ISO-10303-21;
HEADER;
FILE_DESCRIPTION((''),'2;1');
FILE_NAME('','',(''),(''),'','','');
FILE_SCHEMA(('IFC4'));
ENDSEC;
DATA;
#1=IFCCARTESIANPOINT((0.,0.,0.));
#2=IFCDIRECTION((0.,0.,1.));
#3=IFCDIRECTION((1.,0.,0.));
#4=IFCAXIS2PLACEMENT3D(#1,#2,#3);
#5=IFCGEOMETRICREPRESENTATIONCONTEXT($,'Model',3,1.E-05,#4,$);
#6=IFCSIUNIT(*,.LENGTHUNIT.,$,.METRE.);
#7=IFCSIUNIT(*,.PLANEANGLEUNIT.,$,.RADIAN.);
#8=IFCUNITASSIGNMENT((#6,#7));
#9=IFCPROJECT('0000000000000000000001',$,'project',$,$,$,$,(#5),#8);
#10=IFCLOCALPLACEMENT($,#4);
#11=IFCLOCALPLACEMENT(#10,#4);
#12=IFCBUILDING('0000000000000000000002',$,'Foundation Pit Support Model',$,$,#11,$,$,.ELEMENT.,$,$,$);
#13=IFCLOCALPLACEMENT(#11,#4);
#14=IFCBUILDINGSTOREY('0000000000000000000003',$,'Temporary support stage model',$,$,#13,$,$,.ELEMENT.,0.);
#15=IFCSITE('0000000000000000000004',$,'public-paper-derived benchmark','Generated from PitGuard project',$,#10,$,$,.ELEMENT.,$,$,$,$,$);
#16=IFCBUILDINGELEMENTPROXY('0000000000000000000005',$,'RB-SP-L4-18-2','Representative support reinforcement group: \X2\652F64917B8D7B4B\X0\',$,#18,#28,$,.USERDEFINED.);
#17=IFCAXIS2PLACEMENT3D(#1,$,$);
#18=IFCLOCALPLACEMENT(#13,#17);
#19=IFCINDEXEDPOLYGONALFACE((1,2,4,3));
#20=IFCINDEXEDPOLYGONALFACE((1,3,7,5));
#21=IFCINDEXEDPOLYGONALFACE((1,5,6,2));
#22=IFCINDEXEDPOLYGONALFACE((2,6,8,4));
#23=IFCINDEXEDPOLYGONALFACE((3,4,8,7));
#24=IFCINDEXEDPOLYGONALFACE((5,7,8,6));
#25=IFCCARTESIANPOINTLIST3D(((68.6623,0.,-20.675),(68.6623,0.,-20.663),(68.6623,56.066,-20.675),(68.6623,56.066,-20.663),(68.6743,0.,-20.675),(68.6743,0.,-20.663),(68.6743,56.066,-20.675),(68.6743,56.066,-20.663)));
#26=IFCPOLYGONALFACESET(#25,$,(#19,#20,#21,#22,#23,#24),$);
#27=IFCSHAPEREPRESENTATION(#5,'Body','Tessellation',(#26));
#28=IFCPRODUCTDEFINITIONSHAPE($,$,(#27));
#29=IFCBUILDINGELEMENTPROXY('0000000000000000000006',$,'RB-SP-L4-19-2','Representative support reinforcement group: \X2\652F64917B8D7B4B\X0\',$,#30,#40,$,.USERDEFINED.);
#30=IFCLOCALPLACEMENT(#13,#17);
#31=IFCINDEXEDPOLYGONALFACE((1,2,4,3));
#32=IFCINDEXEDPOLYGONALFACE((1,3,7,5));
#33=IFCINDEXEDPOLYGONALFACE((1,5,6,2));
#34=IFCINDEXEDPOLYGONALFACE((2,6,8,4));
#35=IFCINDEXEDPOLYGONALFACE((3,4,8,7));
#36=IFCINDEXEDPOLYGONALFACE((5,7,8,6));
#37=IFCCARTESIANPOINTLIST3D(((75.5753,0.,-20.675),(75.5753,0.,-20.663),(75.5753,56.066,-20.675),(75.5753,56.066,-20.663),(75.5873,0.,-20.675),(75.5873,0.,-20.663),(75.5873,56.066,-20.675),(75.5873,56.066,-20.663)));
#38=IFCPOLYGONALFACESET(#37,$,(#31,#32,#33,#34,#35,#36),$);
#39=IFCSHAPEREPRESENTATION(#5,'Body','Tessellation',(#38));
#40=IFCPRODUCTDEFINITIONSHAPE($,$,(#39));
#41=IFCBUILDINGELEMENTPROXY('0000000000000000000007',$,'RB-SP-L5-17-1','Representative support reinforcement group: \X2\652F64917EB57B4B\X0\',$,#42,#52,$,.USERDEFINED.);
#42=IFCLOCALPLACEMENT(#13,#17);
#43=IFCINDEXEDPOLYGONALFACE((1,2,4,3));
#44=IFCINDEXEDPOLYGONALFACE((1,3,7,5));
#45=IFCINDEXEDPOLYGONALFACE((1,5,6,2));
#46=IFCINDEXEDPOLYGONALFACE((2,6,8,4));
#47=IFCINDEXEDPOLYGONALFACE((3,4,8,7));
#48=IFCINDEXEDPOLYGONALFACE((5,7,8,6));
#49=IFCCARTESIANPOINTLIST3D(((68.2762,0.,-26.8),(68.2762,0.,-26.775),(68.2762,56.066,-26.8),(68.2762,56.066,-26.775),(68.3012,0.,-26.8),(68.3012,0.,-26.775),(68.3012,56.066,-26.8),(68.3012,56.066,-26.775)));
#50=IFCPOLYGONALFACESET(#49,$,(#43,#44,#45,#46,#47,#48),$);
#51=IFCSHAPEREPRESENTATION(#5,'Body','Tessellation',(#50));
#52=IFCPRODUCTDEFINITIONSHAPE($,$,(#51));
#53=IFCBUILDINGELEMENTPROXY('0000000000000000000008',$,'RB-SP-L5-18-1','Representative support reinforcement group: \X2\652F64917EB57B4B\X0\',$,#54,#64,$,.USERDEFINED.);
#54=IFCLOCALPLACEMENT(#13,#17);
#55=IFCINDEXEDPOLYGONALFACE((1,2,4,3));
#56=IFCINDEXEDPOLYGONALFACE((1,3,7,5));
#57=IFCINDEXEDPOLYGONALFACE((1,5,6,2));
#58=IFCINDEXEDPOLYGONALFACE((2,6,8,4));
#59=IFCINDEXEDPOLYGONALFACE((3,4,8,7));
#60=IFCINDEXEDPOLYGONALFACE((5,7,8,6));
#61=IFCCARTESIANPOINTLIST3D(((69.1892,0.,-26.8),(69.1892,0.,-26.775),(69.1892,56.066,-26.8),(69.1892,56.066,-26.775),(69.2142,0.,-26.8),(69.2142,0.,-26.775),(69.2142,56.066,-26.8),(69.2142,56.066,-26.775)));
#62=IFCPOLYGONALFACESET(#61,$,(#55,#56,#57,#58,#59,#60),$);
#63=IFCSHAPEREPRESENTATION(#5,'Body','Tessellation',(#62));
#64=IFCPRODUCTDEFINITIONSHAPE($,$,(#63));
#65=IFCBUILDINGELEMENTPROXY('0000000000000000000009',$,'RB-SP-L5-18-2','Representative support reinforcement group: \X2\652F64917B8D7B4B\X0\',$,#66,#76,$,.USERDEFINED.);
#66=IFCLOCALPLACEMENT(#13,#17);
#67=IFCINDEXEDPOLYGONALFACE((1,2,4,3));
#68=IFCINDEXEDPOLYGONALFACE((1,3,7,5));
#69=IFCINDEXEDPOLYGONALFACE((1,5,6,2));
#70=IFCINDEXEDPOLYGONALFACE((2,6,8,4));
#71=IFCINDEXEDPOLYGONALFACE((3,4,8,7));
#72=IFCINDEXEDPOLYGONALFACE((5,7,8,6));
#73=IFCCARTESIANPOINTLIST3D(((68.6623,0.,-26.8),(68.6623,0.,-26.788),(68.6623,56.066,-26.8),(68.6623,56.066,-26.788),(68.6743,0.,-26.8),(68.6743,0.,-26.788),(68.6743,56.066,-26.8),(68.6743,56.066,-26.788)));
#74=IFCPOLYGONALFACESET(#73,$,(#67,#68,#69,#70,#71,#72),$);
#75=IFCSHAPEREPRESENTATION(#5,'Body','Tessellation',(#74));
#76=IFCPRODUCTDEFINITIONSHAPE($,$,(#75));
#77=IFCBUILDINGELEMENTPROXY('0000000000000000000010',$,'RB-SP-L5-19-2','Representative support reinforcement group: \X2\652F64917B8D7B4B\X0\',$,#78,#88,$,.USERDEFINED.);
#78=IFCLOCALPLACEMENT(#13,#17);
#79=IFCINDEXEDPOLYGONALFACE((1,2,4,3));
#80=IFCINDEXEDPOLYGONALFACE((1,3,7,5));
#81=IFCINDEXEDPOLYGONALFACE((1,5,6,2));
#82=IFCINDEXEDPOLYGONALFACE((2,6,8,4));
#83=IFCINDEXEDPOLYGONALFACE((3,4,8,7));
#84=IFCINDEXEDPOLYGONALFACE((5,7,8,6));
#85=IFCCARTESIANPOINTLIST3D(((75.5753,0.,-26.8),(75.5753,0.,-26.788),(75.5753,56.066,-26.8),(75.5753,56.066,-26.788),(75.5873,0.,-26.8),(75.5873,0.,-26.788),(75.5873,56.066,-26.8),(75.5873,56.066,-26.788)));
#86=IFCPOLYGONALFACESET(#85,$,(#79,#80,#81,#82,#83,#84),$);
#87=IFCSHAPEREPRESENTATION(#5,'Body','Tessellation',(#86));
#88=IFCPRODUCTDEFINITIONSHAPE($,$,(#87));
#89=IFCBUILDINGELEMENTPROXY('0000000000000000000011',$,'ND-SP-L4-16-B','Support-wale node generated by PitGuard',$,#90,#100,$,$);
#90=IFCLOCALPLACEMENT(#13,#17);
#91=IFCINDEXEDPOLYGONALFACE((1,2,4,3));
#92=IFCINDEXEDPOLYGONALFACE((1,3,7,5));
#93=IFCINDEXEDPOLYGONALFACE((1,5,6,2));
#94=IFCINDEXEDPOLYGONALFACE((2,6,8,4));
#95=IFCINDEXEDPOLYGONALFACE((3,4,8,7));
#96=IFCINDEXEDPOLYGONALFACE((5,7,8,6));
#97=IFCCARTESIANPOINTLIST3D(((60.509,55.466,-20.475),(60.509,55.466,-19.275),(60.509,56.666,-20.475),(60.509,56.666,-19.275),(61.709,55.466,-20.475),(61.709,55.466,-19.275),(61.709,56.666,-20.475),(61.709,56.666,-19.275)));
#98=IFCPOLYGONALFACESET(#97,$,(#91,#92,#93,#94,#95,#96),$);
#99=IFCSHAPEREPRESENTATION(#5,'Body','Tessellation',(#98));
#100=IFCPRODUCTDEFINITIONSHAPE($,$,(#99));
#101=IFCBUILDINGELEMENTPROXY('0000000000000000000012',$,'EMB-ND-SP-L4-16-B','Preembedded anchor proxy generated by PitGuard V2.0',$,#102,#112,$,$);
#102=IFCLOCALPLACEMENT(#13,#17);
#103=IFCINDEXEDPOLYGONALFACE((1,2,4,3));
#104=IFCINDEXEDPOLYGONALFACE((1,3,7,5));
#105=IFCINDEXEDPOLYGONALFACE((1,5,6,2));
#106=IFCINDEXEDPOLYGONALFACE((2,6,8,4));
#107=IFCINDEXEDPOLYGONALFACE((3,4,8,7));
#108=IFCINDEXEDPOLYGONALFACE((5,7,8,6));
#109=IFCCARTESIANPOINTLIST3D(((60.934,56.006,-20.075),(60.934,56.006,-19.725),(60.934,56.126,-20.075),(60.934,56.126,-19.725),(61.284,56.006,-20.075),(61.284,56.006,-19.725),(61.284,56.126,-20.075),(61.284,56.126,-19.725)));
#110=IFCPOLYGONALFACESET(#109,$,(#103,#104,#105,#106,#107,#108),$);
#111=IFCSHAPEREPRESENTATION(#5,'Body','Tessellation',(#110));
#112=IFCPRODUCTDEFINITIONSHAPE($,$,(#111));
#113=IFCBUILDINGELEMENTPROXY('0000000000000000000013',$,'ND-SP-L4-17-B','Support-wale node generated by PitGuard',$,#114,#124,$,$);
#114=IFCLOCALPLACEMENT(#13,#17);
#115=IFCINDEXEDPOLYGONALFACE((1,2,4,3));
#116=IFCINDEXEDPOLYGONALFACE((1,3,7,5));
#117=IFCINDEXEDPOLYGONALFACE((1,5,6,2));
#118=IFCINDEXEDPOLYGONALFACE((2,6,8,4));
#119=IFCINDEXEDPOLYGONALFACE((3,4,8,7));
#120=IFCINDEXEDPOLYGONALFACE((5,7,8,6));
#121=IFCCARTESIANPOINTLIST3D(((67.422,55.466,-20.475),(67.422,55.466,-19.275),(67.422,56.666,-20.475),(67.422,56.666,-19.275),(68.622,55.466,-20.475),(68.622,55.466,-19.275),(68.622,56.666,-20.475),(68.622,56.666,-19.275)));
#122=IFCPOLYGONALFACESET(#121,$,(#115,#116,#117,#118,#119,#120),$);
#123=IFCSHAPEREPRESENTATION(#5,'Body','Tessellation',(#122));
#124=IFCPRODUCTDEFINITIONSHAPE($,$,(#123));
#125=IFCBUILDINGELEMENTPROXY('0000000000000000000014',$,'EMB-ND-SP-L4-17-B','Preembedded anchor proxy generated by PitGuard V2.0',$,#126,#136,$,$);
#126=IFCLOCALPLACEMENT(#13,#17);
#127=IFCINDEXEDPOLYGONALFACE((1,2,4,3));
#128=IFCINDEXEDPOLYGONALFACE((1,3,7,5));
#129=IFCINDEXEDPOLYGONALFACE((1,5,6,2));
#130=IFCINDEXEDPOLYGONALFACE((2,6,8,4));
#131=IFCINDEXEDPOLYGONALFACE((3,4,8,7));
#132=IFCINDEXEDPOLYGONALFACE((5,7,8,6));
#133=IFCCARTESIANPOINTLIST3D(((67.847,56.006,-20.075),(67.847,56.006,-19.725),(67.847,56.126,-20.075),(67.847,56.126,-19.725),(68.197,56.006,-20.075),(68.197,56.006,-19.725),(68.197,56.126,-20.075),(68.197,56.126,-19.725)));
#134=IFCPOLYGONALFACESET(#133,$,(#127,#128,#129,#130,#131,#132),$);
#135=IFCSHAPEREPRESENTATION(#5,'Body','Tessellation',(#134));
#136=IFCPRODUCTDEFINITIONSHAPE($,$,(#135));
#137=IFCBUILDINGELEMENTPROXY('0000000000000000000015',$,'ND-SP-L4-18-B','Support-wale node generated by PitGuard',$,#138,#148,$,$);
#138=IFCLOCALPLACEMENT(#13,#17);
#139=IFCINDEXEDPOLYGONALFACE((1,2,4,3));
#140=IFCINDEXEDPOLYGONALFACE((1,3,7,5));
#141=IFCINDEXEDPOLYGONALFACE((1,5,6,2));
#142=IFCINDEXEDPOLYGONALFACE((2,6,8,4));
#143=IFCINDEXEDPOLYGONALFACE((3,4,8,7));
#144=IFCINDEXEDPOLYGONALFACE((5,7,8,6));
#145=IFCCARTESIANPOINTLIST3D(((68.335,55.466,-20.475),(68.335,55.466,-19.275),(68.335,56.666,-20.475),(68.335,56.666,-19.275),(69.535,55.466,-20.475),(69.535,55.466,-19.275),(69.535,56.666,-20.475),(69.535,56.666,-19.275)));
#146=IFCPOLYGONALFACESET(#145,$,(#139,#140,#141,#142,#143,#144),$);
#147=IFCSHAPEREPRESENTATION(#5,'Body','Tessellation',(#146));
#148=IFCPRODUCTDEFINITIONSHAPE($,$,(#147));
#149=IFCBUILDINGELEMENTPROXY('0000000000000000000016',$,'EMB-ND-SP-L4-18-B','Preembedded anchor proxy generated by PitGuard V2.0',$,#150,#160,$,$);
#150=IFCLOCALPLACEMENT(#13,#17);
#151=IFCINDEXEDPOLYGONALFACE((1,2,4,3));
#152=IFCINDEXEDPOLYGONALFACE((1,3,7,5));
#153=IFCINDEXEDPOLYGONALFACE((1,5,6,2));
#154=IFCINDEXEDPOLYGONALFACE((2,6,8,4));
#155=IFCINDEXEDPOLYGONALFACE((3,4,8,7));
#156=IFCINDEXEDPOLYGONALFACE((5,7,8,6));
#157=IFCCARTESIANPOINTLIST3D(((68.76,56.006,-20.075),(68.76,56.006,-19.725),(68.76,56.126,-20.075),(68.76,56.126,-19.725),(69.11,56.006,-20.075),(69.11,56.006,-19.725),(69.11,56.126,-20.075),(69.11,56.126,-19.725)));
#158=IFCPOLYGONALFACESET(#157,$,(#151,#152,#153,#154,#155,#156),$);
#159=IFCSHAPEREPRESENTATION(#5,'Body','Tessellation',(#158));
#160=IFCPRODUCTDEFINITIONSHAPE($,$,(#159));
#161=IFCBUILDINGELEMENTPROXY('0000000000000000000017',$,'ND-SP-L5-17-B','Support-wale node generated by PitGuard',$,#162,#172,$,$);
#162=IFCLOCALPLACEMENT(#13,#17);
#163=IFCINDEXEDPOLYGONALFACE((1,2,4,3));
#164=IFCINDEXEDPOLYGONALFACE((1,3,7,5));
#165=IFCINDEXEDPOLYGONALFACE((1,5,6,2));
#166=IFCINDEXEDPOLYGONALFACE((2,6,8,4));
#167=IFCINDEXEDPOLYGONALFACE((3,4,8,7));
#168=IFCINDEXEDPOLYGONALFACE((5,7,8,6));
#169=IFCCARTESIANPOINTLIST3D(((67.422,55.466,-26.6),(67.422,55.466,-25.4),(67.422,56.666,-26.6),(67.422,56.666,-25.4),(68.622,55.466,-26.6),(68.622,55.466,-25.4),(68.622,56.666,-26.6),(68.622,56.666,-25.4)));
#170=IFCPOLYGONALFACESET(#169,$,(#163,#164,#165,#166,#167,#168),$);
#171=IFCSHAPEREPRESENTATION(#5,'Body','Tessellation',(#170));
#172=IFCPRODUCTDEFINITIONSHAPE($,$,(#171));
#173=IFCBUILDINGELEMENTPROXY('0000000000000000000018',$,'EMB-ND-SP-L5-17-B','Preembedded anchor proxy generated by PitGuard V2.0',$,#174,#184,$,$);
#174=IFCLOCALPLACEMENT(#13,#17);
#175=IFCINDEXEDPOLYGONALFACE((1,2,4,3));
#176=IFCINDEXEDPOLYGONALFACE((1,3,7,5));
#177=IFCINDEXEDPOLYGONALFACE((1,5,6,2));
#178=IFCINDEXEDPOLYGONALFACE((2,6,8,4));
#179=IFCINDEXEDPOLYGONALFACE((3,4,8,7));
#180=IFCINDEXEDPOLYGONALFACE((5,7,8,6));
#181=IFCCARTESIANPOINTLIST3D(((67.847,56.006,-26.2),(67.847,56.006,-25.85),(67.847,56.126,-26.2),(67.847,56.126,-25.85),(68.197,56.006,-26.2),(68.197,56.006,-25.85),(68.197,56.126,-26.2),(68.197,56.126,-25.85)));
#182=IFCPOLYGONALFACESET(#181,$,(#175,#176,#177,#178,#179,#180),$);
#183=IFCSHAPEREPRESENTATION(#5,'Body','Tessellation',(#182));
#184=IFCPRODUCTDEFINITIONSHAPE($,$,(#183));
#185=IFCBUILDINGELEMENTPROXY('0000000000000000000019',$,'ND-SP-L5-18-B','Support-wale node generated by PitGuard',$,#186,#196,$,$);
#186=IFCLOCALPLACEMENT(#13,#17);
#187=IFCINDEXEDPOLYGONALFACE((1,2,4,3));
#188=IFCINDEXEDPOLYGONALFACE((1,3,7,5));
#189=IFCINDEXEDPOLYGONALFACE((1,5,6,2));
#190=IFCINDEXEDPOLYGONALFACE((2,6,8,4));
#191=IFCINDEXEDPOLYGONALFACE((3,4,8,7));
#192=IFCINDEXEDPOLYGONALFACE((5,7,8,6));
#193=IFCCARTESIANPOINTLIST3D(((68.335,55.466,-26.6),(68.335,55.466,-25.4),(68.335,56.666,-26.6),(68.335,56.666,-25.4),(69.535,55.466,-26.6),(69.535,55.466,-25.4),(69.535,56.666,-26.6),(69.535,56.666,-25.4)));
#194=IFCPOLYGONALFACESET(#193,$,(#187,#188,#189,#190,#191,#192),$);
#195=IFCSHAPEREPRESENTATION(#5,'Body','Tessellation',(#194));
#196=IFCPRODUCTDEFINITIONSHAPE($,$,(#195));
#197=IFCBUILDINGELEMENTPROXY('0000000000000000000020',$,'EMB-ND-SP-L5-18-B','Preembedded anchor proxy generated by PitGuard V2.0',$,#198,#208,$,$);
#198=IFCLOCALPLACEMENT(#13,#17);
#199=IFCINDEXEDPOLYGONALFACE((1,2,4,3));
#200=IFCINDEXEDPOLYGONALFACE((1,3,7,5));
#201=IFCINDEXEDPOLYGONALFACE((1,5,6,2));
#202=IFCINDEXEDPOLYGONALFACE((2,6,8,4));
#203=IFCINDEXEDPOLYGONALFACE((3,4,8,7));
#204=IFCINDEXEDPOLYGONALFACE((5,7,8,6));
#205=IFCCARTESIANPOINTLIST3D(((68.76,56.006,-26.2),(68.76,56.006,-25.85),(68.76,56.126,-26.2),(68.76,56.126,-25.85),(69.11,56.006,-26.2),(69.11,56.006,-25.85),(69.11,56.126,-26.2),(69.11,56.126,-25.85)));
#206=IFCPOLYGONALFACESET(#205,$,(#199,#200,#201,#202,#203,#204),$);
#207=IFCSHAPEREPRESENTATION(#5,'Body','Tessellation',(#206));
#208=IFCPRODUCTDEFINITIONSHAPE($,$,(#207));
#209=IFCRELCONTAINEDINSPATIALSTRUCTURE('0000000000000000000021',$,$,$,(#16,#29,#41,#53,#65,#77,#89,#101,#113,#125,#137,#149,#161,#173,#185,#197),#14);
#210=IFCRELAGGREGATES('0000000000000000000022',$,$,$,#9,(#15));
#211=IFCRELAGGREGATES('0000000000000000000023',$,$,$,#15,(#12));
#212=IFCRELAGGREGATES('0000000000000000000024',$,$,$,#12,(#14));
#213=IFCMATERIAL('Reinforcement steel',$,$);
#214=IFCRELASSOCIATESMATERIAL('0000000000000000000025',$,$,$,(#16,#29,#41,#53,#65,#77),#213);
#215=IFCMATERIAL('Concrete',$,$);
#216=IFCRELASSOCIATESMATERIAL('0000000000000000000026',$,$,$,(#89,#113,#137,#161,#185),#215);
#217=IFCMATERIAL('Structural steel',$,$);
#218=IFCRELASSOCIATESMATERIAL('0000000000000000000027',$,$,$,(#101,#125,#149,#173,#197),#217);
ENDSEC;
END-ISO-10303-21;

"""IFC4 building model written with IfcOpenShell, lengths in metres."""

from ifc_helpers import new_model, si_unit, frame, origin_with_axes, origin_2d, place, context, project, spatial, rectangle, extrude, material, element, save


model = new_model("IFC4")

# Units and contexts
model_context = context("Model", 3, precision=1e-05, world=origin_with_axes())
ifc_project = project(units=[si_unit("LENGTHUNIT", "METRE"), si_unit("PLANEANGLEUNIT", "RADIAN")], contexts=[model_context])

# Site, building, storey
site_placement = place(None, origin_with_axes())
site = spatial("IfcSite", under=ifc_project, at=site_placement, Name="public-paper-derived benchmark", Description="Generated from PitGuard project", CompositionType="ELEMENT")
building_placement = place(site_placement, origin_with_axes())
building = spatial("IfcBuilding", under=site, at=building_placement, Name="Foundation Pit Support Model", CompositionType="ELEMENT")
storey_placement = place(building_placement, origin_with_axes())
storey = spatial("IfcBuildingStorey", under=building, at=storey_placement, Name="Temporary support stage model", CompositionType="ELEMENT", Elevation=0.0)

# Shared definitions
ifc_material_1 = material(Name="Structural steel")

# Shared definitions
ifc_material_2 = material(Name="Concrete")

# Building element proxies
ifc_material_3 = material(Name="Reinforcement steel")
for number, where, z_axis, x_axis, name in (
    (1, (68.6683, 28.033, -20.675), (0.0, 0.0, 1.0), (0.0, 1.0, 0.0), "RB-SP-L4-18-2"),
    (2, (75.5813, 28.033, -20.675), (0.0, 0.0, 1.0), (0.0, 1.0, 0.0), "RB-SP-L4-19-2"),
):
    element("IfcBuildingElementProxy", number, at=place(storey_placement, frame(where, z_axis=z_axis, x_axis=x_axis)), inside=storey, material=ifc_material_3, Name=name, Description="Representative support reinforcement group: 支撑箍筋", PredefinedType="USERDEFINED", context=model_context, shape_type="SweptSolid", body=[
        extrude(rectangle(XDim=56.066, YDim=0.012, at=origin_2d()), origin_with_axes(), (0.0, 0.0, 1.0), 0.012),
    ])
for number, where, z_axis, x_axis, name in (
    (3, (68.2887, 28.033, -26.8), (0.0, 0.0, 1.0), (0.0, 1.0, 0.0), "RB-SP-L5-17-1"),
    (4, (69.2017, 28.033, -26.8), (0.0, 0.0, 1.0), (0.0, 1.0, 0.0), "RB-SP-L5-18-1"),
):
    element("IfcBuildingElementProxy", number, at=place(storey_placement, frame(where, z_axis=z_axis, x_axis=x_axis)), inside=storey, material=ifc_material_3, Name=name, Description="Representative support reinforcement group: 支撑纵筋", PredefinedType="USERDEFINED", context=model_context, shape_type="SweptSolid", body=[
        extrude(rectangle(XDim=56.066, YDim=0.025, at=origin_2d()), origin_with_axes(), (0.0, 0.0, 1.0), 0.025),
    ])
for number, where, z_axis, x_axis, name in (
    (5, (68.6683, 28.033, -26.8), (0.0, 0.0, 1.0), (0.0, 1.0, 0.0), "RB-SP-L5-18-2"),
    (6, (75.5813, 28.033, -26.8), (0.0, 0.0, 1.0), (0.0, 1.0, 0.0), "RB-SP-L5-19-2"),
):
    element("IfcBuildingElementProxy", number, at=place(storey_placement, frame(where, z_axis=z_axis, x_axis=x_axis)), inside=storey, material=ifc_material_3, Name=name, Description="Representative support reinforcement group: 支撑箍筋", PredefinedType="USERDEFINED", context=model_context, shape_type="SweptSolid", body=[
        extrude(rectangle(XDim=56.066, YDim=0.012, at=origin_2d()), origin_with_axes(), (0.0, 0.0, 1.0), 0.012),
    ])
proxy_1_placement = place(storey_placement, frame((61.109, 56.066, -20.475), z_axis=(0.0, 0.0, 1.0), x_axis=(1.0, 0.0, 0.0)))
element("IfcBuildingElementProxy", 7, at=proxy_1_placement, inside=storey, material=ifc_material_2, Name="ND-SP-L4-16-B", Description="Support-wale node generated by PitGuard", context=model_context, shape_type="SweptSolid", body=[
    extrude(rectangle(XDim=1.2, YDim=1.2, at=origin_2d()), origin_with_axes(), (0.0, 0.0, 1.0), 1.2),
])
proxy_2_placement = place(storey_placement, frame((61.109, 56.066, -20.075), z_axis=(0.0, 0.0, 1.0), x_axis=(1.0, 0.0, 0.0)))
element("IfcBuildingElementProxy", 8, at=proxy_2_placement, inside=storey, material=ifc_material_1, Name="EMB-ND-SP-L4-16-B", Description="Preembedded anchor proxy generated by PitGuard V2.0", context=model_context, shape_type="SweptSolid", body=[
    extrude(rectangle(XDim=0.35, YDim=0.12, at=origin_2d()), origin_with_axes(), (0.0, 0.0, 1.0), 0.35),
])
proxy_3_placement = place(storey_placement, frame((68.022, 56.066, -20.475), z_axis=(0.0, 0.0, 1.0), x_axis=(1.0, 0.0, 0.0)))
element("IfcBuildingElementProxy", 9, at=proxy_3_placement, inside=storey, material=ifc_material_2, Name="ND-SP-L4-17-B", Description="Support-wale node generated by PitGuard", context=model_context, shape_type="SweptSolid", body=[
    extrude(rectangle(XDim=1.2, YDim=1.2, at=origin_2d()), origin_with_axes(), (0.0, 0.0, 1.0), 1.2),
])
proxy_4_placement = place(storey_placement, frame((68.022, 56.066, -20.075), z_axis=(0.0, 0.0, 1.0), x_axis=(1.0, 0.0, 0.0)))
element("IfcBuildingElementProxy", 10, at=proxy_4_placement, inside=storey, material=ifc_material_1, Name="EMB-ND-SP-L4-17-B", Description="Preembedded anchor proxy generated by PitGuard V2.0", context=model_context, shape_type="SweptSolid", body=[
    extrude(rectangle(XDim=0.35, YDim=0.12, at=origin_2d()), origin_with_axes(), (0.0, 0.0, 1.0), 0.35),
])
proxy_5_placement = place(storey_placement, frame((68.935, 56.066, -20.475), z_axis=(0.0, 0.0, 1.0), x_axis=(1.0, 0.0, 0.0)))
element("IfcBuildingElementProxy", 11, at=proxy_5_placement, inside=storey, material=ifc_material_2, Name="ND-SP-L4-18-B", Description="Support-wale node generated by PitGuard", context=model_context, shape_type="SweptSolid", body=[
    extrude(rectangle(XDim=1.2, YDim=1.2, at=origin_2d()), origin_with_axes(), (0.0, 0.0, 1.0), 1.2),
])
proxy_6_placement = place(storey_placement, frame((68.935, 56.066, -20.075), z_axis=(0.0, 0.0, 1.0), x_axis=(1.0, 0.0, 0.0)))
element("IfcBuildingElementProxy", 12, at=proxy_6_placement, inside=storey, material=ifc_material_1, Name="EMB-ND-SP-L4-18-B", Description="Preembedded anchor proxy generated by PitGuard V2.0", context=model_context, shape_type="SweptSolid", body=[
    extrude(rectangle(XDim=0.35, YDim=0.12, at=origin_2d()), origin_with_axes(), (0.0, 0.0, 1.0), 0.35),
])
proxy_7_placement = place(storey_placement, frame((68.022, 56.066, -26.6), z_axis=(0.0, 0.0, 1.0), x_axis=(1.0, 0.0, 0.0)))
element("IfcBuildingElementProxy", 13, at=proxy_7_placement, inside=storey, material=ifc_material_2, Name="ND-SP-L5-17-B", Description="Support-wale node generated by PitGuard", context=model_context, shape_type="SweptSolid", body=[
    extrude(rectangle(XDim=1.2, YDim=1.2, at=origin_2d()), origin_with_axes(), (0.0, 0.0, 1.0), 1.2),
])
proxy_8_placement = place(storey_placement, frame((68.022, 56.066, -26.2), z_axis=(0.0, 0.0, 1.0), x_axis=(1.0, 0.0, 0.0)))
element("IfcBuildingElementProxy", 14, at=proxy_8_placement, inside=storey, material=ifc_material_1, Name="EMB-ND-SP-L5-17-B", Description="Preembedded anchor proxy generated by PitGuard V2.0", context=model_context, shape_type="SweptSolid", body=[
    extrude(rectangle(XDim=0.35, YDim=0.12, at=origin_2d()), origin_with_axes(), (0.0, 0.0, 1.0), 0.35),
])
proxy_9_placement = place(storey_placement, frame((68.935, 56.066, -26.6), z_axis=(0.0, 0.0, 1.0), x_axis=(1.0, 0.0, 0.0)))
element("IfcBuildingElementProxy", 15, at=proxy_9_placement, inside=storey, material=ifc_material_2, Name="ND-SP-L5-18-B", Description="Support-wale node generated by PitGuard", context=model_context, shape_type="SweptSolid", body=[
    extrude(rectangle(XDim=1.2, YDim=1.2, at=origin_2d()), origin_with_axes(), (0.0, 0.0, 1.0), 1.2),
])
proxy_10_placement = place(storey_placement, frame((68.935, 56.066, -26.2), z_axis=(0.0, 0.0, 1.0), x_axis=(1.0, 0.0, 0.0)))
element("IfcBuildingElementProxy", 16, at=proxy_10_placement, inside=storey, material=ifc_material_1, Name="EMB-ND-SP-L5-18-B", Description="Preembedded anchor proxy generated by PitGuard V2.0", context=model_context, shape_type="SweptSolid", body=[
    extrude(rectangle(XDim=0.35, YDim=0.12, at=origin_2d()), origin_with_axes(), (0.0, 0.0, 1.0), 0.35),
])

save(model, "model.ifc")
